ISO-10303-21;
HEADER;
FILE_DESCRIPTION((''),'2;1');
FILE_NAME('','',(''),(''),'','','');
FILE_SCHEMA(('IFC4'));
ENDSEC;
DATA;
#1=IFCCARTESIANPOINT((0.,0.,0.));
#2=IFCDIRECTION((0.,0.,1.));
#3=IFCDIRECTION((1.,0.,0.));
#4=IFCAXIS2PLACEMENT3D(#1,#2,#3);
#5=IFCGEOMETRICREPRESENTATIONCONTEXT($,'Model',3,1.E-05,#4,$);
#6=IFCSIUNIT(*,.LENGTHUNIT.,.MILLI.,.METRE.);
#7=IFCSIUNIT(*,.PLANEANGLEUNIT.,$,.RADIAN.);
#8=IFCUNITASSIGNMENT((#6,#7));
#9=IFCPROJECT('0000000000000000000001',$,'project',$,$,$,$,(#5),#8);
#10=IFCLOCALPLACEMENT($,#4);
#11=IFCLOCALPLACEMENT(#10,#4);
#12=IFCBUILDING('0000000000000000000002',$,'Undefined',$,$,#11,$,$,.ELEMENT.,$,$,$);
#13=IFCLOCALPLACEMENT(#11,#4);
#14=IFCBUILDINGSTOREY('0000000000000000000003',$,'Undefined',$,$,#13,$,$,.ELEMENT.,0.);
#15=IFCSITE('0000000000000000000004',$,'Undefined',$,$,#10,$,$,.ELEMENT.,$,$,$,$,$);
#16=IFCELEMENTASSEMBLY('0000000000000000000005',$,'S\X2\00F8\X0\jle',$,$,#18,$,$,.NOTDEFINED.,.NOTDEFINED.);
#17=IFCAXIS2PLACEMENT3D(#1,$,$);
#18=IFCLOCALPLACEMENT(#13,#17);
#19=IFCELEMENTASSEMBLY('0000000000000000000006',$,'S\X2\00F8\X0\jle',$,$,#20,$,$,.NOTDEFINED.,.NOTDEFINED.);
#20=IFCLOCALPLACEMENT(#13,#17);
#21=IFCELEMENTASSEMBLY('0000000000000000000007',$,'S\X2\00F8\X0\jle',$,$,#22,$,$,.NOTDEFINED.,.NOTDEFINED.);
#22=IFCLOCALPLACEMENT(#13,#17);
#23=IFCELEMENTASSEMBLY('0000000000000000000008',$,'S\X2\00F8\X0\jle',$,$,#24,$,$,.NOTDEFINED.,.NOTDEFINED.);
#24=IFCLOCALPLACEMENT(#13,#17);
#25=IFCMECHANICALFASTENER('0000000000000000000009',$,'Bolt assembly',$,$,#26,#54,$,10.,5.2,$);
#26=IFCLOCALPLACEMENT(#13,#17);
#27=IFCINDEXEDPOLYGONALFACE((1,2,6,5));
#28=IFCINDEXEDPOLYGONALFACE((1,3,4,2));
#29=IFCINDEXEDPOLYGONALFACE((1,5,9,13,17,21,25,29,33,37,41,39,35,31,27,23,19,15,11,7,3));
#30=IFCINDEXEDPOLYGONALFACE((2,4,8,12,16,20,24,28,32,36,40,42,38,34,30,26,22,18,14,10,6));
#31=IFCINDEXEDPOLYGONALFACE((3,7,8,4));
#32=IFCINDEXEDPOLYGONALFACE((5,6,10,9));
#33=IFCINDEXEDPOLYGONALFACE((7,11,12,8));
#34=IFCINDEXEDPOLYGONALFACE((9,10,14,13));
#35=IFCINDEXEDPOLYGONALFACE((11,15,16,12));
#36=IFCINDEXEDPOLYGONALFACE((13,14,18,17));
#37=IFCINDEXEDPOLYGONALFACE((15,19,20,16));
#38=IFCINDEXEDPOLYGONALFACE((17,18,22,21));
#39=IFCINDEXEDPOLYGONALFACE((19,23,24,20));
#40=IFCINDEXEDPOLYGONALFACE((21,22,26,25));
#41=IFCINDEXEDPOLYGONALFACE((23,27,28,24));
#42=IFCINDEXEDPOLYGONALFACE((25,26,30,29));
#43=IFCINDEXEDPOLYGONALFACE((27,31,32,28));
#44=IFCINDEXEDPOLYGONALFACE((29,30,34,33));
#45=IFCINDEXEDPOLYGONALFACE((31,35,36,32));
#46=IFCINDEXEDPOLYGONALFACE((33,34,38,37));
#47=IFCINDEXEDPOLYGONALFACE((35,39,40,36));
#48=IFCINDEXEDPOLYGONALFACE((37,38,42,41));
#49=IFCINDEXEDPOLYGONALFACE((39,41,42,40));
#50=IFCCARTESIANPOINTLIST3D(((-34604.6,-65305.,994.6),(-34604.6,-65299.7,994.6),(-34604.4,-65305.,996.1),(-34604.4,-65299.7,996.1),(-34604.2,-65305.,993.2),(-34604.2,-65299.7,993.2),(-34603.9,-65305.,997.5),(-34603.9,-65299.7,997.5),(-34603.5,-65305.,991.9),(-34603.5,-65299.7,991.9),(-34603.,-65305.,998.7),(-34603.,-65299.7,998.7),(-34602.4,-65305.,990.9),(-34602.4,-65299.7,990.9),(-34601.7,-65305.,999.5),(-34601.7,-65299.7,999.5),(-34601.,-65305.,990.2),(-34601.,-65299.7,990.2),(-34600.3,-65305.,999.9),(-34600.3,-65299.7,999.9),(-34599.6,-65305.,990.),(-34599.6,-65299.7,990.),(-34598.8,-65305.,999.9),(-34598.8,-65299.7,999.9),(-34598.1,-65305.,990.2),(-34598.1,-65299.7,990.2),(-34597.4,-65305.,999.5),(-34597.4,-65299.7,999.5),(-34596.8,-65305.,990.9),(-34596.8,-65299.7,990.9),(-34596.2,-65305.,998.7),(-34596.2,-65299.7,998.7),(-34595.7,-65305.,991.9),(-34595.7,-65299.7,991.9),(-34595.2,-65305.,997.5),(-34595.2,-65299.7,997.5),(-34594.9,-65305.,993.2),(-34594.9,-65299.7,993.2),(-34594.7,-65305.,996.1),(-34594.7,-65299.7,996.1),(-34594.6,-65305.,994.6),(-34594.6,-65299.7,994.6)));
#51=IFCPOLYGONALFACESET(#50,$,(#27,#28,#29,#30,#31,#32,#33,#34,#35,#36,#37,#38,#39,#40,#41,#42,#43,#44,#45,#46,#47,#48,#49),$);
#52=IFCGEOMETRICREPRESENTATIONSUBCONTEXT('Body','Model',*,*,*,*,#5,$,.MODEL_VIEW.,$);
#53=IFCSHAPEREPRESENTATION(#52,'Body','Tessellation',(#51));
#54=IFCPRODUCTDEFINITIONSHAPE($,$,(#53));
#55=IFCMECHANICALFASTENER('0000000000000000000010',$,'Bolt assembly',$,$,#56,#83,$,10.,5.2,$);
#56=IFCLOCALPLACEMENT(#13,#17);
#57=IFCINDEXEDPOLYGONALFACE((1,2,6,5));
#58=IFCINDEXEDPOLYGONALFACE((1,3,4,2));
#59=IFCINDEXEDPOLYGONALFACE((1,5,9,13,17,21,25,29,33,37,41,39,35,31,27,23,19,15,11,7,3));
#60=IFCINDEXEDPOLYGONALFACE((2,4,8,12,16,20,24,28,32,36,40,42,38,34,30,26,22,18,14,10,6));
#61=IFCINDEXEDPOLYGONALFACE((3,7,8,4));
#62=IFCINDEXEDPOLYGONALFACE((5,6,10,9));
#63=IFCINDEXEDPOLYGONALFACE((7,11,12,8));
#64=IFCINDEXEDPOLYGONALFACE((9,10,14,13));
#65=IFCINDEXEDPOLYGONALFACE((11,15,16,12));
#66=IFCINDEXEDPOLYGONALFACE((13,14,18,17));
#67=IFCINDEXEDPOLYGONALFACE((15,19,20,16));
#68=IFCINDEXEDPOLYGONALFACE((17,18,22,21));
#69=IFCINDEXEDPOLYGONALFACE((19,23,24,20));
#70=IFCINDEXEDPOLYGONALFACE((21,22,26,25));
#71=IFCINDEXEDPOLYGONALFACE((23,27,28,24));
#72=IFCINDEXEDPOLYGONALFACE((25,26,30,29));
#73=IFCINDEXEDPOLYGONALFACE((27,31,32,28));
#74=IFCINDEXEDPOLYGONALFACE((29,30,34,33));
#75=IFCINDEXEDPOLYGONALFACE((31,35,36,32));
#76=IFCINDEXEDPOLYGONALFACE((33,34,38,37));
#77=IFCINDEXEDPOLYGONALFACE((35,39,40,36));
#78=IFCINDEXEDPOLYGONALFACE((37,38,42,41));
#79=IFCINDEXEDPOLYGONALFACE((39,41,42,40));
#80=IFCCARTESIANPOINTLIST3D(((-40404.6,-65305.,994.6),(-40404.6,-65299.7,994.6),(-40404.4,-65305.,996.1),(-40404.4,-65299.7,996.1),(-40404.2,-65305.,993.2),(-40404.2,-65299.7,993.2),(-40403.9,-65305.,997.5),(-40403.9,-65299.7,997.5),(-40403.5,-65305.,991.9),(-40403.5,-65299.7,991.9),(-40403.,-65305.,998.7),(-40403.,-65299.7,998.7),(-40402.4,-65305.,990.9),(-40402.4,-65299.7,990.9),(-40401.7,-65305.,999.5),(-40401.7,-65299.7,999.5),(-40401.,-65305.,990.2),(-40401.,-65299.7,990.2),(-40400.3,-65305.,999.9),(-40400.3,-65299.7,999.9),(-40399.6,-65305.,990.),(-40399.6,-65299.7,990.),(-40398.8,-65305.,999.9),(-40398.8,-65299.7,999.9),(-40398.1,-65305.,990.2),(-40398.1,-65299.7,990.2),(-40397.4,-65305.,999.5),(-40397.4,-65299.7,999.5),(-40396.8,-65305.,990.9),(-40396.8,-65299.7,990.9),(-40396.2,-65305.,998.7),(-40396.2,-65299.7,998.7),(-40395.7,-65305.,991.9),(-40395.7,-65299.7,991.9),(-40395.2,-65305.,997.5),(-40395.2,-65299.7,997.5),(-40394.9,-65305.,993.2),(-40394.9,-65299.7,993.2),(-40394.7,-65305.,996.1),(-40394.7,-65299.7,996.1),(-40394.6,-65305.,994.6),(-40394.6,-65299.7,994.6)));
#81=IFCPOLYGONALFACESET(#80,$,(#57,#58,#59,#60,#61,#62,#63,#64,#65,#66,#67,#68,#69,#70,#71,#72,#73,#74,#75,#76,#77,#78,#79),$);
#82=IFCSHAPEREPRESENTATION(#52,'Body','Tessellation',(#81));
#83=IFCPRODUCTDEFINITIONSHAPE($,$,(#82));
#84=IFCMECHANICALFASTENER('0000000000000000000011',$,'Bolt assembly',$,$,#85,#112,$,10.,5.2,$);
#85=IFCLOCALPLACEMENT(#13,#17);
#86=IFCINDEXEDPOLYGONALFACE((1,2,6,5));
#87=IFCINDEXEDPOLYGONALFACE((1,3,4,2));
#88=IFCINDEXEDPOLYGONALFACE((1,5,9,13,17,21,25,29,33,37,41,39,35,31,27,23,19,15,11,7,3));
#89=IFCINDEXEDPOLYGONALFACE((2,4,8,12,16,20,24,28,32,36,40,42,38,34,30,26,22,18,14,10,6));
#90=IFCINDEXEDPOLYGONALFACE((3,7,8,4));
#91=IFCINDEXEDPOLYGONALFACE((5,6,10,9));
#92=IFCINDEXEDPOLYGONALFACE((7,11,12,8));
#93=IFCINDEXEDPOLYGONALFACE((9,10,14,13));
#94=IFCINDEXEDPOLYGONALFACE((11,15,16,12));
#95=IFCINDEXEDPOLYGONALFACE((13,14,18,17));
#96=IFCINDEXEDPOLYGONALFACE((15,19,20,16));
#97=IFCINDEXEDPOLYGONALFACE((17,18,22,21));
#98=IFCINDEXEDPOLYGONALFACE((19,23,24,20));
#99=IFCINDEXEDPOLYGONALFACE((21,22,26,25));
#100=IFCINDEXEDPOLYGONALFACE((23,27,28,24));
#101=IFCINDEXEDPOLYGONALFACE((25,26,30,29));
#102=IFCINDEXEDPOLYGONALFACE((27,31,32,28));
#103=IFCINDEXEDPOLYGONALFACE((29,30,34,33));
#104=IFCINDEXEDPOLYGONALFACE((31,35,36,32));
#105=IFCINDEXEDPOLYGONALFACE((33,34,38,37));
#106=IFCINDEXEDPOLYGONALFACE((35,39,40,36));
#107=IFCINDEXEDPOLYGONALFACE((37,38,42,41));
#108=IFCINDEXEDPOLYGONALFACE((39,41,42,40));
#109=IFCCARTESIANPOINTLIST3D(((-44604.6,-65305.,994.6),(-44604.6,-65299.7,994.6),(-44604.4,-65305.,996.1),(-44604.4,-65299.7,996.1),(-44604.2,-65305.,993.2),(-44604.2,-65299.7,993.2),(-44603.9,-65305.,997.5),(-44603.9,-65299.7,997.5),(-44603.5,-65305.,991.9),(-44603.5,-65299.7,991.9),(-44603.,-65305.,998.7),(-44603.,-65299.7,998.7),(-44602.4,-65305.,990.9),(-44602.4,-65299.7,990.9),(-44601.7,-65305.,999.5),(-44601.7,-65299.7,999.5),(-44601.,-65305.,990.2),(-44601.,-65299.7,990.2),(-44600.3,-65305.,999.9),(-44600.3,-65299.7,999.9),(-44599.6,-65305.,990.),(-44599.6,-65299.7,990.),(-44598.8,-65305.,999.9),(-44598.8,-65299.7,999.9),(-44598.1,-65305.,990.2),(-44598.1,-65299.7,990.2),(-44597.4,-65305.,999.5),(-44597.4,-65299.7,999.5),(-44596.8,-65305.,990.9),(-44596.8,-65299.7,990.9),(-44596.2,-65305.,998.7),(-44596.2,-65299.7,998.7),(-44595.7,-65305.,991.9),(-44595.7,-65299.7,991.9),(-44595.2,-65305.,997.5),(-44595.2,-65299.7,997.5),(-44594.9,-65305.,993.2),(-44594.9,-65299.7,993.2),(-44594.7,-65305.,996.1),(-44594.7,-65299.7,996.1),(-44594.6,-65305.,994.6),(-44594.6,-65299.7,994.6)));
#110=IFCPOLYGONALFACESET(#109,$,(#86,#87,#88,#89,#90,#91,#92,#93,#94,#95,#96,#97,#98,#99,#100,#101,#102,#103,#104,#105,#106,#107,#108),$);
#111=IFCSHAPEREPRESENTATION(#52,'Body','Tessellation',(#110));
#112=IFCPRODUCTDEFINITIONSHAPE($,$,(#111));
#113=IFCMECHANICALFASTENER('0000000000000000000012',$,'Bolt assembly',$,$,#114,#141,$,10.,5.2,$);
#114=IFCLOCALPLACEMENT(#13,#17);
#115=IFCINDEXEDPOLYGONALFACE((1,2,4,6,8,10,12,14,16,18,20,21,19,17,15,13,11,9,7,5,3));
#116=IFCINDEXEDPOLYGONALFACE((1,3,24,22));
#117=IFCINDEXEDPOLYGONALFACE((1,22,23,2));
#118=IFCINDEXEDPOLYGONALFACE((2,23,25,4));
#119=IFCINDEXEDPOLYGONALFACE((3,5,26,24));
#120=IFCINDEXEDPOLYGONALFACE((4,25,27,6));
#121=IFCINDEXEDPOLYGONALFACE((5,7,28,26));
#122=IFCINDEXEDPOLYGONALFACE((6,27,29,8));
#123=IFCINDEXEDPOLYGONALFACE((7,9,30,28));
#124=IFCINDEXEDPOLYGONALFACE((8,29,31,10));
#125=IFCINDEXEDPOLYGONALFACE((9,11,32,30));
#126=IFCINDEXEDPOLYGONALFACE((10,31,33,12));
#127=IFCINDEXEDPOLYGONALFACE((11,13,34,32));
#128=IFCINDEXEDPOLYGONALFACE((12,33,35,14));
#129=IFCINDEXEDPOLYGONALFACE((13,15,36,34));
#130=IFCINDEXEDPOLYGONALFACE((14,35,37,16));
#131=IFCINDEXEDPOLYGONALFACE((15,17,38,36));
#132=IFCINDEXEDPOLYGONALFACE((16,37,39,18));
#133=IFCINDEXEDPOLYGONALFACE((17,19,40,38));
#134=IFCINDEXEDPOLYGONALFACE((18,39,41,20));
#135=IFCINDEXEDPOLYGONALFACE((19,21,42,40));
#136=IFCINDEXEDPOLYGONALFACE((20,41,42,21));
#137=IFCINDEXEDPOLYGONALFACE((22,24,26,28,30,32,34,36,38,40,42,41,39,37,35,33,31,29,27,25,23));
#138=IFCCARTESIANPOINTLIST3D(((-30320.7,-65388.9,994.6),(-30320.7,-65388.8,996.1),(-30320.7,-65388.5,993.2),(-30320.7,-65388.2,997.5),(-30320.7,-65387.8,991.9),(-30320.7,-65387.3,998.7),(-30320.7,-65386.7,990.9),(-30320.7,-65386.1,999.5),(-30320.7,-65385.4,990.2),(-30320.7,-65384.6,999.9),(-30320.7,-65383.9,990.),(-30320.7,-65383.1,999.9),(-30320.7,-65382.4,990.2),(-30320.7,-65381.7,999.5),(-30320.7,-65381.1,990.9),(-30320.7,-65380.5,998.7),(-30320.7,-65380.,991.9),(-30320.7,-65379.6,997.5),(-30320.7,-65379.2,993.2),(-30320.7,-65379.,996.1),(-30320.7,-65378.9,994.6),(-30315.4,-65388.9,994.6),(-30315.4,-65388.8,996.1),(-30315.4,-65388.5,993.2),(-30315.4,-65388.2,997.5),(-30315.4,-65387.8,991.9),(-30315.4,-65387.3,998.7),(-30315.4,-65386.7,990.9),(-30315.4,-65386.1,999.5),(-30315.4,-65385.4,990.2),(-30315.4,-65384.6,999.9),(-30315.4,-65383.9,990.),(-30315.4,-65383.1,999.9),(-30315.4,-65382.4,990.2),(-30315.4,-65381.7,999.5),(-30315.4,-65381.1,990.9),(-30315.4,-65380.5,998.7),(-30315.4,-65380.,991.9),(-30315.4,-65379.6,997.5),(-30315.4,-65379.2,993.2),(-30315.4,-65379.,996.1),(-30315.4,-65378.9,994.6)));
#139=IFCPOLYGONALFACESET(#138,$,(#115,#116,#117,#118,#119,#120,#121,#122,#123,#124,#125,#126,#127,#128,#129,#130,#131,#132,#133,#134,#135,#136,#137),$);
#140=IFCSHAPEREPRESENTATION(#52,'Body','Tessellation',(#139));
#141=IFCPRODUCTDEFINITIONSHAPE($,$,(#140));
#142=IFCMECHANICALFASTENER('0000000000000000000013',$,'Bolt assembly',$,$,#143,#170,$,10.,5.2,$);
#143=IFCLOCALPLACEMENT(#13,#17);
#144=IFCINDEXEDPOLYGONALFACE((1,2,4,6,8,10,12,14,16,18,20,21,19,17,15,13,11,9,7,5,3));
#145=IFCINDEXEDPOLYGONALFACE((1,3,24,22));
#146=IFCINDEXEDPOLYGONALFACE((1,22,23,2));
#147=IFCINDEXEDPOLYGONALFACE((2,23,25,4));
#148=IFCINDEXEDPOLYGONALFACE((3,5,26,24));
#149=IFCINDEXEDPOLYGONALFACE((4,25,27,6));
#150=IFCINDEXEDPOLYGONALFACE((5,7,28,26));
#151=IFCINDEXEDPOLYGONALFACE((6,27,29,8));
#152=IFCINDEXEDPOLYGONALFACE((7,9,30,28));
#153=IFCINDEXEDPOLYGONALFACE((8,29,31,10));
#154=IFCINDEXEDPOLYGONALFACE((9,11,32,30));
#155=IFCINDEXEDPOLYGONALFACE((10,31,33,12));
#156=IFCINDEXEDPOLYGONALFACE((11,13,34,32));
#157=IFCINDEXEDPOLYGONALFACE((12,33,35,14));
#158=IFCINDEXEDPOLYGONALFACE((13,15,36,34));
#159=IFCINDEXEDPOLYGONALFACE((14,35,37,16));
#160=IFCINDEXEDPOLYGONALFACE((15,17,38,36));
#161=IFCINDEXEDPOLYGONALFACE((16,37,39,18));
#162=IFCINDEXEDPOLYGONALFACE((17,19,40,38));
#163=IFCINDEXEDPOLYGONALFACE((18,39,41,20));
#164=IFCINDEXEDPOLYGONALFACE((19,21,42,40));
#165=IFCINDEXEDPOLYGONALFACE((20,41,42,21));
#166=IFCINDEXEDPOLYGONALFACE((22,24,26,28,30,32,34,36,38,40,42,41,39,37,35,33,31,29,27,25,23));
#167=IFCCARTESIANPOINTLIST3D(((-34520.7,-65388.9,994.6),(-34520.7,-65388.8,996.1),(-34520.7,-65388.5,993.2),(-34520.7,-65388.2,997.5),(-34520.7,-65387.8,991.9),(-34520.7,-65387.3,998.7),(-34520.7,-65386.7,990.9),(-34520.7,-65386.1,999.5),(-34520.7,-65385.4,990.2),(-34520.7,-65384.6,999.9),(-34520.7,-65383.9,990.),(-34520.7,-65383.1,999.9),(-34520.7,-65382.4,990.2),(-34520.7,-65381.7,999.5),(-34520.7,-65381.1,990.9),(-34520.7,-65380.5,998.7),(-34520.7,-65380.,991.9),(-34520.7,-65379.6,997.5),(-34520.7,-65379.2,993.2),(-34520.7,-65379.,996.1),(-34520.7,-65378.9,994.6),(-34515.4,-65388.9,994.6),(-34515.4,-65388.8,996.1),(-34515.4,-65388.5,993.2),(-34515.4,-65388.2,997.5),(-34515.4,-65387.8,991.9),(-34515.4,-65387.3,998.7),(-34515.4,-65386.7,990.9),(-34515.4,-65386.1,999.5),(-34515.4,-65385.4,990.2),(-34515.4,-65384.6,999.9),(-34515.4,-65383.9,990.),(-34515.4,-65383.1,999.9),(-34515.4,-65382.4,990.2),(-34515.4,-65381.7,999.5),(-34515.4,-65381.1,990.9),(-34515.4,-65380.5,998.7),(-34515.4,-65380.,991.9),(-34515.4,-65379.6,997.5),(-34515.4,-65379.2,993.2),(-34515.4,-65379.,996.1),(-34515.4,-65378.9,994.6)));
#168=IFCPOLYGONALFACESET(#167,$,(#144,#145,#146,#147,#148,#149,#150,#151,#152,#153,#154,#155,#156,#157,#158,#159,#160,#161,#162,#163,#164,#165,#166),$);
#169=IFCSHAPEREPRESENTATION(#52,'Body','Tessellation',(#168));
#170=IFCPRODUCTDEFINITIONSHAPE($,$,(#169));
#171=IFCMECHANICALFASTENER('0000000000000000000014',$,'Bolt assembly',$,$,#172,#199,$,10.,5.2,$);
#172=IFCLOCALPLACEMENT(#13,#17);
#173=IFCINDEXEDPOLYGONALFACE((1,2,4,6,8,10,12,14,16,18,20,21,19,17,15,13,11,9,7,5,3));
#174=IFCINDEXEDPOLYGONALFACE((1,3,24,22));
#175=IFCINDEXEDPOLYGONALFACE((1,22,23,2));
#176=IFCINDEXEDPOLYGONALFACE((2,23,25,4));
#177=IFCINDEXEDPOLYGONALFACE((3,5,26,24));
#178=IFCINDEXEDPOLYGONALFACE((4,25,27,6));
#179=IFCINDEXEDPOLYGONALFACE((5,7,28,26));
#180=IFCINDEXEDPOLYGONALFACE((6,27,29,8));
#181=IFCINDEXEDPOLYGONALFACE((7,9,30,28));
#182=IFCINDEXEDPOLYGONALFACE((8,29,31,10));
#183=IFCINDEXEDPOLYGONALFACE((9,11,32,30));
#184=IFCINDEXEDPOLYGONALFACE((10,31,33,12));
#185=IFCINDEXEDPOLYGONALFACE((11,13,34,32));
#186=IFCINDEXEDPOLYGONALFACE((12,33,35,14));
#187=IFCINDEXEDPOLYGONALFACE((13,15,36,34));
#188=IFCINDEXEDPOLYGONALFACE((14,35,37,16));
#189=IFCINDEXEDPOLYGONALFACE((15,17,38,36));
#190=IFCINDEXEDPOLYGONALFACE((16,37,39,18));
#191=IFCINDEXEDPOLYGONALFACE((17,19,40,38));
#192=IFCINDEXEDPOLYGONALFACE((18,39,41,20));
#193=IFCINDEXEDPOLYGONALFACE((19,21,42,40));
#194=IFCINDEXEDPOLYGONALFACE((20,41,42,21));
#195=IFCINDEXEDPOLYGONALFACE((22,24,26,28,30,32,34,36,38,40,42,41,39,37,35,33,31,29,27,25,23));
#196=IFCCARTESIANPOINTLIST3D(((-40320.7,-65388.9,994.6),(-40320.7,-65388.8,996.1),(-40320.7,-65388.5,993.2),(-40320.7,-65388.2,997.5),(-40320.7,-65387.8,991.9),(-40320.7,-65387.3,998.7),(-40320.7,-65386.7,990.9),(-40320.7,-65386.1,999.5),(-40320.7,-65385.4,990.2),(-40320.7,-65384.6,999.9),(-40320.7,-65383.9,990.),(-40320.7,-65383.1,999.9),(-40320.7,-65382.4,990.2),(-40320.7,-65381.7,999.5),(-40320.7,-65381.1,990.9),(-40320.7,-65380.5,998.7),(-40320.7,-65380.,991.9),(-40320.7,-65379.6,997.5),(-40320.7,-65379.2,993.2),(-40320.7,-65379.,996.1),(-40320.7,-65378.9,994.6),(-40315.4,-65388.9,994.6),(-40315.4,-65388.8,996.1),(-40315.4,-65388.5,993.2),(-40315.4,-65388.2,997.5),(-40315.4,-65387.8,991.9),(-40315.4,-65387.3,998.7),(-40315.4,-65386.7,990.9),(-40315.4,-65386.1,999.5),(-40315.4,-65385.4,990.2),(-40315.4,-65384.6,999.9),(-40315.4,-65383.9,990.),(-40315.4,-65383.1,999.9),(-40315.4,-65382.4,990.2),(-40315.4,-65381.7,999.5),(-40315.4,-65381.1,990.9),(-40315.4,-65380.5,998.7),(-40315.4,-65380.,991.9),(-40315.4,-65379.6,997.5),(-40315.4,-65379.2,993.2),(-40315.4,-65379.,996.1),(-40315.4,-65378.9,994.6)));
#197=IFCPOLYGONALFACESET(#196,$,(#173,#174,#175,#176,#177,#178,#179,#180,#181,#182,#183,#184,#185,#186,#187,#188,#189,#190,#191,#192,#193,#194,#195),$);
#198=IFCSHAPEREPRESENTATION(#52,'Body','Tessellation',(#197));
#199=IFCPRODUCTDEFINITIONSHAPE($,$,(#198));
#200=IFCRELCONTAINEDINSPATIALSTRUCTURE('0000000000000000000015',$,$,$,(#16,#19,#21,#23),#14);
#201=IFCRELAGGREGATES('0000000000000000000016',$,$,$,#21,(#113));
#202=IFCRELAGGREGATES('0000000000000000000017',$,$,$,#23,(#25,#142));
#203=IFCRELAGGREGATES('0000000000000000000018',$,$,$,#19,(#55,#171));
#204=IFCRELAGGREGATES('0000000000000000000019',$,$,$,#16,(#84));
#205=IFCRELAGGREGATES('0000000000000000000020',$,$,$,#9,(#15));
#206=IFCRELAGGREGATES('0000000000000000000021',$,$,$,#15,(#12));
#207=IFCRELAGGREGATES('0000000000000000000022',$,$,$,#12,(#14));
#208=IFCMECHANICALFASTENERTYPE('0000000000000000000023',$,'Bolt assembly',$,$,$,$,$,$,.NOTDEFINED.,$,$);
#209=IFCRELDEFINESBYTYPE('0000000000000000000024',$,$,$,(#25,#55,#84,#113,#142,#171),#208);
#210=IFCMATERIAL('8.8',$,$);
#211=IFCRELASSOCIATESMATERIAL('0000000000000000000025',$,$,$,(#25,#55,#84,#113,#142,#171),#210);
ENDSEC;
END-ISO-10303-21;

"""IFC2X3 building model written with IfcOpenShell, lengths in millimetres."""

from ifc_helpers import new_model, si_unit, frame, origin_with_axes, origin_2d_with_axis, place, context, subcontext, project, spatial, circle, extrude, source, transform, mapped, material, type_object, element, aggregate, save


model = new_model("IFC2X3")

# Units and contexts
model_context = context("Model", 3, precision=1e-05, world=origin_with_axes())
body_context = subcontext(model_context, "Body", "Model", "MODEL_VIEW")
ifc_project = project(units=[si_unit("LENGTHUNIT", "METRE", prefix="MILLI"), si_unit("PLANEANGLEUNIT", "RADIAN")], contexts=[model_context])

# Site, building, storey
site_placement = place(None, origin_with_axes())
site = spatial("IfcSite", under=ifc_project, at=site_placement, Name="Undefined", CompositionType="ELEMENT")
building_placement = place(site_placement, origin_with_axes())
building = spatial("IfcBuilding", under=site, at=building_placement, Name="Undefined", CompositionType="ELEMENT")
storey_placement = place(building_placement, origin_with_axes())
storey = spatial("IfcBuildingStorey", under=building, at=storey_placement, Name="Undefined", CompositionType="ELEMENT", Elevation=0.0)

# Element assembly
assembly_1_placement = place(storey_placement, origin_with_axes())
assembly_1 = element("IfcElementAssembly", 1, at=assembly_1_placement, inside=storey, Name="Søjle", AssemblyPlace="NOTDEFINED", PredefinedType="NOTDEFINED")

# Element assemblies
assembly_2_placement = place(storey_placement, origin_with_axes())
assembly_2 = element("IfcElementAssembly", 2, at=assembly_2_placement, inside=storey, Name="Søjle", AssemblyPlace="NOTDEFINED", PredefinedType="NOTDEFINED")
assembly_3_placement = place(storey_placement, origin_with_axes())
assembly_3 = element("IfcElementAssembly", 3, at=assembly_3_placement, inside=storey, Name="Søjle", AssemblyPlace="NOTDEFINED", PredefinedType="NOTDEFINED")
assembly_4_placement = place(storey_placement, origin_with_axes())
assembly_4 = element("IfcElementAssembly", 4, at=assembly_4_placement, inside=storey, Name="Søjle", AssemblyPlace="NOTDEFINED", PredefinedType="NOTDEFINED")

# Shared definitions
ifc_material_1 = material(Name="8.8")
mechanical_fastener_type = type_object("IfcMechanicalFastenerType", Name="Bolt assembly")

# Mechanical fasteners
shared_shape_1 = source(origin_with_axes(), body_context, "Body", "SweptSolid", [
    extrude(circle(Radius=5.0, at=origin_2d_with_axis()), frame((0.0, 0.0, 0.0), z_axis=(0.0, 1.0, 0.0), x_axis=(1.0, 0.0, 0.0)), (0.0, 0.0, 1.0), 5.3),
])
mechanical_fastener_1_placement = place(assembly_4_placement, frame((-34599.6, -65299.7, 995.0), z_axis=(-1.0, 0.0, 0.0), x_axis=(0.0, 0.0, -1.0)))
mechanical_fastener_1 = element("IfcMechanicalFastener", 5, at=mechanical_fastener_1_placement, type_object=mechanical_fastener_type, material=ifc_material_1, Name="Bolt assembly", NominalDiameter=10.0, NominalLength=5.2, context=body_context, shape_type="MappedRepresentation", body=[
    mapped(shared_shape_1, transform((0.0, 0.0, 0.0))),
])
mechanical_fastener_2_placement = place(assembly_2_placement, frame((-40399.6, -65299.7, 995.0), z_axis=(-1.0, 0.0, 0.0), x_axis=(0.0, 0.0, -1.0)))
mechanical_fastener_2 = element("IfcMechanicalFastener", 6, at=mechanical_fastener_2_placement, type_object=mechanical_fastener_type, material=ifc_material_1, Name="Bolt assembly", NominalDiameter=10.0, NominalLength=5.2, context=body_context, shape_type="MappedRepresentation", body=[
    mapped(shared_shape_1, transform((0.0, 0.0, 0.0))),
])
mechanical_fastener_3_placement = place(assembly_1_placement, frame((-44599.6, -65299.7, 995.0), z_axis=(-1.0, 0.0, 0.0), x_axis=(0.0, 0.0, -1.0)))
mechanical_fastener_3 = element("IfcMechanicalFastener", 7, at=mechanical_fastener_3_placement, type_object=mechanical_fastener_type, material=ifc_material_1, Name="Bolt assembly", NominalDiameter=10.0, NominalLength=5.2, context=body_context, shape_type="MappedRepresentation", body=[
    mapped(shared_shape_1, transform((0.0, 0.0, 0.0))),
])
shared_shape_2 = source(origin_with_axes(), body_context, "Body", "SweptSolid", [
    extrude(circle(Radius=5.0, at=origin_2d_with_axis()), frame((0.0, 0.0, 0.0), z_axis=(0.0, 1.0, 0.0), x_axis=(1.0, 0.0, 0.0)), (0.0, 0.0, 1.0), 5.3),
])
mechanical_fastener_4_placement = place(assembly_3_placement, frame((-30315.4, -65383.9, 995.0), z_axis=(0.0, 1.0, 0.0), x_axis=(0.0, 0.0, -1.0)))
mechanical_fastener_4 = element("IfcMechanicalFastener", 8, at=mechanical_fastener_4_placement, type_object=mechanical_fastener_type, material=ifc_material_1, Name="Bolt assembly", NominalDiameter=10.0, NominalLength=5.2, context=body_context, shape_type="MappedRepresentation", body=[
    mapped(shared_shape_2, transform((0.0, 0.0, 0.0))),
])
aggregate(assembly_3, [mechanical_fastener_4])
mechanical_fastener_5_placement = place(assembly_4_placement, frame((-34515.4, -65383.9, 995.0), z_axis=(0.0, 1.0, 0.0), x_axis=(0.0, 0.0, -1.0)))
mechanical_fastener_5 = element("IfcMechanicalFastener", 9, at=mechanical_fastener_5_placement, type_object=mechanical_fastener_type, material=ifc_material_1, Name="Bolt assembly", NominalDiameter=10.0, NominalLength=5.2, context=body_context, shape_type="MappedRepresentation", body=[
    mapped(shared_shape_2, transform((0.0, 0.0, 0.0))),
])
aggregate(assembly_4, [mechanical_fastener_1, mechanical_fastener_5])
mechanical_fastener_6_placement = place(assembly_2_placement, frame((-40315.4, -65383.9, 995.0), z_axis=(0.0, 1.0, 0.0), x_axis=(0.0, 0.0, -1.0)))
mechanical_fastener_6 = element("IfcMechanicalFastener", 10, at=mechanical_fastener_6_placement, type_object=mechanical_fastener_type, material=ifc_material_1, Name="Bolt assembly", NominalDiameter=10.0, NominalLength=5.2, context=body_context, shape_type="MappedRepresentation", body=[
    mapped(shared_shape_2, transform((0.0, 0.0, 0.0))),
])
aggregate(assembly_2, [mechanical_fastener_2, mechanical_fastener_6])
aggregate(assembly_1, [mechanical_fastener_3])

save(model, "model.ifc")
